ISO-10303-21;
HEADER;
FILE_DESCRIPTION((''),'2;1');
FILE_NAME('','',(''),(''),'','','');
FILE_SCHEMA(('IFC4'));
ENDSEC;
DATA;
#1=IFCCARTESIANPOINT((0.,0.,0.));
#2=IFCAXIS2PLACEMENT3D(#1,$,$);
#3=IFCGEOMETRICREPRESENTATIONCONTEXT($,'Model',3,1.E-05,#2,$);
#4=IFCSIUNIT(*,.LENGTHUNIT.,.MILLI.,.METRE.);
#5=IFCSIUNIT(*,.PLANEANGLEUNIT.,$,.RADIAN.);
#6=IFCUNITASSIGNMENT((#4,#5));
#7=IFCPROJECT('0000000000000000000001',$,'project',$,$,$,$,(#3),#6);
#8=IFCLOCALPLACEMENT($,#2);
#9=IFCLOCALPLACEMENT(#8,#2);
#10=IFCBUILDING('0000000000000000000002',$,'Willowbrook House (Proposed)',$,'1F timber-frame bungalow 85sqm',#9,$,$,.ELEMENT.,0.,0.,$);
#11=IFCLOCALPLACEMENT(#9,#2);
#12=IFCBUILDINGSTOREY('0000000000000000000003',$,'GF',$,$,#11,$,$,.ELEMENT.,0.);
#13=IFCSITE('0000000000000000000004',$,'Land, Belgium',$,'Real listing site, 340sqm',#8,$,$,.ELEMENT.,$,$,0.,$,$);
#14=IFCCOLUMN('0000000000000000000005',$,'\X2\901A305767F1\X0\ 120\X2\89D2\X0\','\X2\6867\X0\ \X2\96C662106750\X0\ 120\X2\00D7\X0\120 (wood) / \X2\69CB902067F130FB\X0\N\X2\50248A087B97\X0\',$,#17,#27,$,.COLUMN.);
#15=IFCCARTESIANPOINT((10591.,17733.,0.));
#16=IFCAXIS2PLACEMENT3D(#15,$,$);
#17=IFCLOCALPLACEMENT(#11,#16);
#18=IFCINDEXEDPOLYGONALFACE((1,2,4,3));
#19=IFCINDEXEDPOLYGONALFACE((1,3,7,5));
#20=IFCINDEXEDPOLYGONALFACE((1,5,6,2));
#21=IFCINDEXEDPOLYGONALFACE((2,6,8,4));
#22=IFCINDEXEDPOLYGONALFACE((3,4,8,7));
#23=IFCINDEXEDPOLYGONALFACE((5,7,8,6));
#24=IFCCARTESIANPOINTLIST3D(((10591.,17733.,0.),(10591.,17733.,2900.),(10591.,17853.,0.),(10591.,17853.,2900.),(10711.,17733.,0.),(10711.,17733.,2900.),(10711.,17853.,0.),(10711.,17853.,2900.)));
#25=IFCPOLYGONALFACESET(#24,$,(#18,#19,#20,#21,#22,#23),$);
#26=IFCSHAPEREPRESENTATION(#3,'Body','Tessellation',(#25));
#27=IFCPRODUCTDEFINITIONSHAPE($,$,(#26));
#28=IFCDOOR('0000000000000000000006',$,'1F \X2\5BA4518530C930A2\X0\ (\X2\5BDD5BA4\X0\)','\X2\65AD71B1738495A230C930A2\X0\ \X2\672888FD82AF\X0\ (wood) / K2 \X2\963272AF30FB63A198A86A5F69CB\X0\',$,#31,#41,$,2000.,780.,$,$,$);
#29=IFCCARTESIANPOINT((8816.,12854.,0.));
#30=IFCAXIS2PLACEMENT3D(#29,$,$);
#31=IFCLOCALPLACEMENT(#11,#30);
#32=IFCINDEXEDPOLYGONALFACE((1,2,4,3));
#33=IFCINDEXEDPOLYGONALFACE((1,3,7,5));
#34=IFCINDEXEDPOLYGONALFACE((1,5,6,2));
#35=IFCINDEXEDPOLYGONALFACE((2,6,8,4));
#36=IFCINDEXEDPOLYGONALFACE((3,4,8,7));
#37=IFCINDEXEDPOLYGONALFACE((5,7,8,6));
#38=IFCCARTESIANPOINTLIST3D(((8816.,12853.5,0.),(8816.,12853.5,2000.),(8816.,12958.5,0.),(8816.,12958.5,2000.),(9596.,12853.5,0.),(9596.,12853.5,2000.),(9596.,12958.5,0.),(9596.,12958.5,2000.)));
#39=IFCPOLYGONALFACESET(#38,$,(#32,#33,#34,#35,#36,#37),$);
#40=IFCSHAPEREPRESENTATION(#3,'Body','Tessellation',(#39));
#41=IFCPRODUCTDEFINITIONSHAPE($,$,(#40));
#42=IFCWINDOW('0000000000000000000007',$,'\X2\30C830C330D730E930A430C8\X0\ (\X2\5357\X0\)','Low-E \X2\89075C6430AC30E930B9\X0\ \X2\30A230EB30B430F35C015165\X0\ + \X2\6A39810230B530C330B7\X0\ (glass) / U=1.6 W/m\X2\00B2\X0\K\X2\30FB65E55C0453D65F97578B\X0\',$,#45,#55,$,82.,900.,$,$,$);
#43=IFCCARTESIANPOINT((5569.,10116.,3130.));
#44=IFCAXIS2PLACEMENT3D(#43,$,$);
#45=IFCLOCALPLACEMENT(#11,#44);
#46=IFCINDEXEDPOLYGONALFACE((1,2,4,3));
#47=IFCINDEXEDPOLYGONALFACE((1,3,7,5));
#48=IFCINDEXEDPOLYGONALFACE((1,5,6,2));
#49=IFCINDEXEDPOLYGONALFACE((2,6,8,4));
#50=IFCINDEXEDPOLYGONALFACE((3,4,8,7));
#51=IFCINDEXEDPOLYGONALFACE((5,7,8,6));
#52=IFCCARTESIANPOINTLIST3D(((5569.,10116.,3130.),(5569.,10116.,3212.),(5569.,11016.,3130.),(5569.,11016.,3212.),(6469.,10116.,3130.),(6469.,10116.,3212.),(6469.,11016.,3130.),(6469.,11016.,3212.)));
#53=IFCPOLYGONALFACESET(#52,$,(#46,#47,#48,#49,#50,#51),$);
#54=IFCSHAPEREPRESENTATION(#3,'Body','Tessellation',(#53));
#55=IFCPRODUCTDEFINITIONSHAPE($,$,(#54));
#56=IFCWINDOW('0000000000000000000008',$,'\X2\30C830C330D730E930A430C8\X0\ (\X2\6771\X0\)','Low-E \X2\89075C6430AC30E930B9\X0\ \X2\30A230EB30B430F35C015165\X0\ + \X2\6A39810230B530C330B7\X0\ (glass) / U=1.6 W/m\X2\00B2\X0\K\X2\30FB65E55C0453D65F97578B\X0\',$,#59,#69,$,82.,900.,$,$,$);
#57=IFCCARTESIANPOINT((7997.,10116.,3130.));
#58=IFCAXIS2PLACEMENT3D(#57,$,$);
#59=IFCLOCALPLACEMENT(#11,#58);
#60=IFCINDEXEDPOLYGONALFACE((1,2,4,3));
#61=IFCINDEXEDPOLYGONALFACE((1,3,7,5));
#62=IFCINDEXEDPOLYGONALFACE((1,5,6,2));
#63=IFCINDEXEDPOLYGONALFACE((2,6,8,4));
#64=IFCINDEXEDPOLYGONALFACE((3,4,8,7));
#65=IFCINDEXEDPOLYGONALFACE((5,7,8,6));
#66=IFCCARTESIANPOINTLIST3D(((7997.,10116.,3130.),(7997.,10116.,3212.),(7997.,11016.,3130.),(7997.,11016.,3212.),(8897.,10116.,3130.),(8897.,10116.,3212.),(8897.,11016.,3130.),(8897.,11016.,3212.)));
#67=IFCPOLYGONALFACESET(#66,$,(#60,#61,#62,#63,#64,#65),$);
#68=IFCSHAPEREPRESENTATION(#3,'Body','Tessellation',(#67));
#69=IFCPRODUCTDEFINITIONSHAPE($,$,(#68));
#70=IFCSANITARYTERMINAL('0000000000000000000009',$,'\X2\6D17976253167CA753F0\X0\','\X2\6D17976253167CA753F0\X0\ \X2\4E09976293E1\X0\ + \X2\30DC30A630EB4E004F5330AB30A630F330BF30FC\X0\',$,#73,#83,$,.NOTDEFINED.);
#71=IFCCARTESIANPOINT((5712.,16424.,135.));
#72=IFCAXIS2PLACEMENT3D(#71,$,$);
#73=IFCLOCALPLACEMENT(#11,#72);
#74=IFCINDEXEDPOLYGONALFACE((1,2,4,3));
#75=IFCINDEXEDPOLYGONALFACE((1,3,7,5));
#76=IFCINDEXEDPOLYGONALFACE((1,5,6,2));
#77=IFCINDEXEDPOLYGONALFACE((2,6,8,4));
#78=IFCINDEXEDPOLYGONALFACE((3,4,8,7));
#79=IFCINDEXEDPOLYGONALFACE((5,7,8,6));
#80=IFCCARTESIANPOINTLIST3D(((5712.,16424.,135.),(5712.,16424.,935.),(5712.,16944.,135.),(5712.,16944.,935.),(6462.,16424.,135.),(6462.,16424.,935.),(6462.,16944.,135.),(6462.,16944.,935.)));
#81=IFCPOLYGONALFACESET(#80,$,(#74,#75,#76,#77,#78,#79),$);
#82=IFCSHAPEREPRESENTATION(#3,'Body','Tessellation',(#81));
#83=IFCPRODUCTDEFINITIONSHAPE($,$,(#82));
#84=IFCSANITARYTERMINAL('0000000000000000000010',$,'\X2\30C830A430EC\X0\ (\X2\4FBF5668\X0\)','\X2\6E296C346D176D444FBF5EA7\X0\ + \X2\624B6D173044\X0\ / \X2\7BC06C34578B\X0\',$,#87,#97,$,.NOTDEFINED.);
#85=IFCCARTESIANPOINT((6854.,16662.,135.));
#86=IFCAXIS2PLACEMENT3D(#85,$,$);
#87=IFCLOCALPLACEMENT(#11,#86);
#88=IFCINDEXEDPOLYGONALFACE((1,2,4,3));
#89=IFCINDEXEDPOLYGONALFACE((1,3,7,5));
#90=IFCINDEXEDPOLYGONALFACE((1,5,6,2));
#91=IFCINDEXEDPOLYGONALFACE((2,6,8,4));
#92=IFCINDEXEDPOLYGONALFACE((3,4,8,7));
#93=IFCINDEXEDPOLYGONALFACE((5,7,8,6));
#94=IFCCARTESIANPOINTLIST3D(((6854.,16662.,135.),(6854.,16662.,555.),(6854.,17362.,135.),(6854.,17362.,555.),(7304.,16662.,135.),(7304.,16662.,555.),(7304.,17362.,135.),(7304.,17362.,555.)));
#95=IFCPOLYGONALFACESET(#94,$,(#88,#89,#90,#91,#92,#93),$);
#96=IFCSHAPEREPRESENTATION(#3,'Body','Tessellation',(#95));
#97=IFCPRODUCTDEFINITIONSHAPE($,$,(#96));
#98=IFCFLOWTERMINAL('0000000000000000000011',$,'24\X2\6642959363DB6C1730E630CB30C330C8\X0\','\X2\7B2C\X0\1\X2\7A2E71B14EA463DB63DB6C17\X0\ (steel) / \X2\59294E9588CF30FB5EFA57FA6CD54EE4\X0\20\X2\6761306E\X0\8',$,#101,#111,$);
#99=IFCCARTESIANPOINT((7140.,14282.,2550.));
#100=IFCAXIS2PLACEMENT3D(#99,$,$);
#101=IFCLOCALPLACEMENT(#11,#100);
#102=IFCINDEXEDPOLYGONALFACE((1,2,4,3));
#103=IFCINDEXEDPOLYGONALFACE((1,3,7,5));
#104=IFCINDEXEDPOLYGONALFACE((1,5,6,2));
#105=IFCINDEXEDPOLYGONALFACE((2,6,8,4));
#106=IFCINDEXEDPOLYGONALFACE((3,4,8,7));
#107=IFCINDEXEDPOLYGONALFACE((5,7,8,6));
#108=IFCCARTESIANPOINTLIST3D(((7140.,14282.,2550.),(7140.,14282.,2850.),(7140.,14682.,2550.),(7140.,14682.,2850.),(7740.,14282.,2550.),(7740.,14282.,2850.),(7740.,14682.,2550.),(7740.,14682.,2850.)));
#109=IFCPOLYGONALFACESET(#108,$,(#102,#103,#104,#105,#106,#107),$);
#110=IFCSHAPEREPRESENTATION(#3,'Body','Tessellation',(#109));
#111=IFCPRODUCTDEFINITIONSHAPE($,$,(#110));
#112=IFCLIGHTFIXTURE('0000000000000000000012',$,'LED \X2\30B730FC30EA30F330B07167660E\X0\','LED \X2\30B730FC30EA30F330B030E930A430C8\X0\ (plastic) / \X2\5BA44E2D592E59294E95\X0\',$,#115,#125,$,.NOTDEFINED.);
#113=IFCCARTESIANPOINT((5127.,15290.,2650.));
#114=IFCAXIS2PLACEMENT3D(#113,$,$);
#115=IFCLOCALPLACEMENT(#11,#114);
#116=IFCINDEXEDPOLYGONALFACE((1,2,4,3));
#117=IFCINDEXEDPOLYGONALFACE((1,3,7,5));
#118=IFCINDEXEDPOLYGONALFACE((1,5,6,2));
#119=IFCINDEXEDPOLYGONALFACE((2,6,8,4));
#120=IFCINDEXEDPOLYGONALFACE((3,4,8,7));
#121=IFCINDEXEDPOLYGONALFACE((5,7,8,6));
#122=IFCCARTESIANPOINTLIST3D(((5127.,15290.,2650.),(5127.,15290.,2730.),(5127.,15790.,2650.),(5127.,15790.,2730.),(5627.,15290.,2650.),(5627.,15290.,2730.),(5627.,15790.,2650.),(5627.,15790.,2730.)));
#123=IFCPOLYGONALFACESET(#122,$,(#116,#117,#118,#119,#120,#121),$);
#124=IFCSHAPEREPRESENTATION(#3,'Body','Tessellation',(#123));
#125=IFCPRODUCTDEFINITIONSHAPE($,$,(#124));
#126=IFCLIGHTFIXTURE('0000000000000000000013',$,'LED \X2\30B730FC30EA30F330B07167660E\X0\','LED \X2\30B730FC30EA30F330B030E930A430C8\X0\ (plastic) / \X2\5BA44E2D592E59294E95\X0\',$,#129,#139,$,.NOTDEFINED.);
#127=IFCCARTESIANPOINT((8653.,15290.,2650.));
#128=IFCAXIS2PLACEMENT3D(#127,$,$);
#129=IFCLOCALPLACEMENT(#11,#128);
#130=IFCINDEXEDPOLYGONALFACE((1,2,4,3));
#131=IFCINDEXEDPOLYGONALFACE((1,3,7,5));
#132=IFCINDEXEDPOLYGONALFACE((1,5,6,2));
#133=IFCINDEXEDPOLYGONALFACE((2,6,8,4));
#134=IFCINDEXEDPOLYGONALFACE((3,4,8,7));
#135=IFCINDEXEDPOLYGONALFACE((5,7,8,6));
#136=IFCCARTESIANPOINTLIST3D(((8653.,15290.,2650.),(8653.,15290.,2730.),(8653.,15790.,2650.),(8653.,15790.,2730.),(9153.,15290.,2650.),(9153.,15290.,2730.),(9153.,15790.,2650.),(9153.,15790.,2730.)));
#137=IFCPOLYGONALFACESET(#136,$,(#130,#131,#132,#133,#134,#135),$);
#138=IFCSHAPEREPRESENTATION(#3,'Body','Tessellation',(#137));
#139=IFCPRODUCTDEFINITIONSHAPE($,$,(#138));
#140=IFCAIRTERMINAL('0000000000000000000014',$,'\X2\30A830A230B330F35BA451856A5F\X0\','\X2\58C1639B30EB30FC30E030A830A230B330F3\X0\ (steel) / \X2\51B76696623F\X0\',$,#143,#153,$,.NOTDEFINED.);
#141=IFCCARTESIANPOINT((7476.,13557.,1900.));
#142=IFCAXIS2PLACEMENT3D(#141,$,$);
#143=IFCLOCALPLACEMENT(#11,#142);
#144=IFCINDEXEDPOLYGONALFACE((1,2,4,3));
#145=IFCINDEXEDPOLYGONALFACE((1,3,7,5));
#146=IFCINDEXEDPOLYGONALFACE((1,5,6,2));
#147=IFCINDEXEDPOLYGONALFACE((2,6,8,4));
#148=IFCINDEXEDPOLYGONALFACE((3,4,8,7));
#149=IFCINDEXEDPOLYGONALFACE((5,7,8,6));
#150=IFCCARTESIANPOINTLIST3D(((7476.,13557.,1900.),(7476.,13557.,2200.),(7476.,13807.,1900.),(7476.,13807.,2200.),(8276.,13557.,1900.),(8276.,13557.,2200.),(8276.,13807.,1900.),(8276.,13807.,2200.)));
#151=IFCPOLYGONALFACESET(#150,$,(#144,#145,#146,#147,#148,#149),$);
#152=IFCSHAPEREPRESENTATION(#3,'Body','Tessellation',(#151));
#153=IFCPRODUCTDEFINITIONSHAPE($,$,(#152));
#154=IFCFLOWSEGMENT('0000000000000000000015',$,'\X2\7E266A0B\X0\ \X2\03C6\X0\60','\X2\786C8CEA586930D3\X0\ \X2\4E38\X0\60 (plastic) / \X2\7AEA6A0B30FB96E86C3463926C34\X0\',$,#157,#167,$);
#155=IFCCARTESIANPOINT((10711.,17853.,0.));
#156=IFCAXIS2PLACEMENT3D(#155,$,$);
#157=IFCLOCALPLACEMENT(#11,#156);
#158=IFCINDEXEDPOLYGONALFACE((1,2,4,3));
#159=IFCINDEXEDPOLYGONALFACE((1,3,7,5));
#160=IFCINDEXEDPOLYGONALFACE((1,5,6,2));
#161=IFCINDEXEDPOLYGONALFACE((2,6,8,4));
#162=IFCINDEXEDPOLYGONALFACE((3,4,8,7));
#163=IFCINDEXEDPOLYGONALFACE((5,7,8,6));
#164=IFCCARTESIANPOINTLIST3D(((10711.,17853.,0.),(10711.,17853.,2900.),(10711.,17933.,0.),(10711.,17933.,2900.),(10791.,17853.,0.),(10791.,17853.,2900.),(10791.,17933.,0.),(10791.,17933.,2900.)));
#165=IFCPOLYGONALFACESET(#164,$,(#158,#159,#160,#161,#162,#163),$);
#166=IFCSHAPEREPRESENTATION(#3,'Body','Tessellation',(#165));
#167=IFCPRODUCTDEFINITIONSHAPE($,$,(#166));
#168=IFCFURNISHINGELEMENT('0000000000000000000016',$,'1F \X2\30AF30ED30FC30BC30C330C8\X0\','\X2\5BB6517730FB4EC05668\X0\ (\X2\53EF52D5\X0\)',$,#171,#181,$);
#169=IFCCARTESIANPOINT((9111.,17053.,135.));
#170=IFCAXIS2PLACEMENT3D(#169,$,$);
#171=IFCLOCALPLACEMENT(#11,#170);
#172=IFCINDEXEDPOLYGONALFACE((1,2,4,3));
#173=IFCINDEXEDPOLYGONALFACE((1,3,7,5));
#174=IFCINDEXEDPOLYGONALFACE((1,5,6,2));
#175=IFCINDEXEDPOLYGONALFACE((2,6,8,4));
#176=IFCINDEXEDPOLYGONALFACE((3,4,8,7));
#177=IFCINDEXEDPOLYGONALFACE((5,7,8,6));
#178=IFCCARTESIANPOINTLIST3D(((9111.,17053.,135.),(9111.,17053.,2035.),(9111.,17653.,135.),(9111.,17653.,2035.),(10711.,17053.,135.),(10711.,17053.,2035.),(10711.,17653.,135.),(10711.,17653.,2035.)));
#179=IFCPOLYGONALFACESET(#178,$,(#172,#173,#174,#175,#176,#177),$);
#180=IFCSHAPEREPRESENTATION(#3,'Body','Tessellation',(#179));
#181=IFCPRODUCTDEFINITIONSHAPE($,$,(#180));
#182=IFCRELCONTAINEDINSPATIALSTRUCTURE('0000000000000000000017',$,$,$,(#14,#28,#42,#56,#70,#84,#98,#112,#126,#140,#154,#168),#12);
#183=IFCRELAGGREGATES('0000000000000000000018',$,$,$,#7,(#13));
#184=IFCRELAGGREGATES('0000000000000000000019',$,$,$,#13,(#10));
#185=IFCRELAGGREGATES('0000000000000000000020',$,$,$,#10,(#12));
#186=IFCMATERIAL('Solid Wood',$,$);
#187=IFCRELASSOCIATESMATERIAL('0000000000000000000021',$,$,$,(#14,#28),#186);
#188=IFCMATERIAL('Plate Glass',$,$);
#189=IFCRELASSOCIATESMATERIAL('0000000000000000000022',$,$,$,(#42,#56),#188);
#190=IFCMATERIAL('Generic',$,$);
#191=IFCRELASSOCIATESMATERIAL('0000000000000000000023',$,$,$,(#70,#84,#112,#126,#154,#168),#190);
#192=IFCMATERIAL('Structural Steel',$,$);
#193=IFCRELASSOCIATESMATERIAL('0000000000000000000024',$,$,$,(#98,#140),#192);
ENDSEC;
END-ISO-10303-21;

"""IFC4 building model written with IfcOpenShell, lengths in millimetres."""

from ifc_helpers import new_model, si_unit, frame, frame_2d, origin, place, context, project, spatial, rectangle, extrude, material, element, save


model = new_model("IFC4")

# Units and contexts
model_context = context("Model", 3, precision=1e-05, world=origin())
ifc_project = project(units=[si_unit("LENGTHUNIT", "METRE", prefix="MILLI"), si_unit("PLANEANGLEUNIT", "RADIAN")], contexts=[model_context])

# Site, building, storey
site_placement = place(None, origin())
site = spatial("IfcSite", under=ifc_project, at=site_placement, Name="Land, Belgium", ObjectType="Real listing site, 340sqm", CompositionType="ELEMENT", RefElevation=0.0)
building_placement = place(site_placement, origin())
building = spatial("IfcBuilding", under=site, at=building_placement, Name="Willowbrook House (Proposed)", ObjectType="1F timber-frame bungalow 85sqm", CompositionType="ELEMENT", ElevationOfRefHeight=0.0, ElevationOfTerrain=0.0)
storey_placement = place(building_placement, origin())
storey = spatial("IfcBuildingStorey", under=building, at=storey_placement, Name="GF", CompositionType="ELEMENT", Elevation=0.0)

# Column
ifc_material_1 = material(Name="Solid Wood")
column_1_placement = place(storey_placement, frame((10591.0, 17733.0, 0.0)))
element("IfcColumn", 1, at=column_1_placement, inside=storey, material=ifc_material_1, Name="通し柱 120角", Description="桧 集成材 120×120 (wood) / 構造柱・N値計算", PredefinedType="COLUMN", context=model_context, shape_type="SweptSolid", body=[
    extrude(rectangle(XDim=120.0, YDim=120.0, at=frame_2d((60.0, 60.0))), frame((10591.0, 17733.0, 0.0)), (0.0, 0.0, 1.0), 2900.0),
])

# Door
door_placement = place(storey_placement, frame((8816.0, 12854.0, 0.0)))
element("IfcDoor", 2, at=door_placement, inside=storey, material=ifc_material_1, Name="1F 室内ドア (寝室)", Description="断熱玄関ドア 木製芯 (wood) / K2 防犯・採風機構", OverallHeight=2000.0, OverallWidth=780.0, context=model_context, shape_type="SweptSolid", body=[
    extrude(rectangle(XDim=780.0, YDim=105.0, at=frame_2d((390.0, 52.0))), frame((8816.0, 12854.0, 0.0)), (0.0, 0.0, 1.0), 2000.0),
])

# Windows
ifc_material_2 = material(Name="Plate Glass")
window_1_placement = place(storey_placement, frame((5569.0, 10116.0, 3130.0)))
element("IfcWindow", 3, at=window_1_placement, inside=storey, material=ifc_material_2, Name="トップライト (南)", Description="Low-E 複層ガラス アルゴン封入 + 樹脂サッシ (glass) / U=1.6 W/m²K・日射取得型", OverallHeight=82.0, OverallWidth=900.0, context=model_context, shape_type="SweptSolid", body=[
    extrude(rectangle(XDim=900.0, YDim=900.0, at=frame_2d((450.0, 450.0))), frame((5569.0, 10116.0, 3130.0)), (0.0, 0.0, 1.0), 82.0),
])
window_2_placement = place(storey_placement, frame((7997.0, 10116.0, 3130.0)))
element("IfcWindow", 4, at=window_2_placement, inside=storey, material=ifc_material_2, Name="トップライト (東)", Description="Low-E 複層ガラス アルゴン封入 + 樹脂サッシ (glass) / U=1.6 W/m²K・日射取得型", OverallHeight=82.0, OverallWidth=900.0, context=model_context, shape_type="SweptSolid", body=[
    extrude(rectangle(XDim=900.0, YDim=900.0, at=frame_2d((450.0, 450.0))), frame((7997.0, 10116.0, 3130.0)), (0.0, 0.0, 1.0), 82.0),
])

# Sanitary terminals
ifc_material_3 = material(Name="Generic")
sanitary_terminal_1_placement = place(storey_placement, frame((5712.0, 16424.0, 135.0)))
element("IfcSanitaryTerminal", 5, at=sanitary_terminal_1_placement, inside=storey, material=ifc_material_3, Name="洗面化粧台", Description="洗面化粧台 三面鏡 + ボウル一体カウンター", PredefinedType="NOTDEFINED", context=model_context, shape_type="SweptSolid", body=[
    extrude(rectangle(XDim=750.0, YDim=520.0, at=frame_2d((375.0, 260.0))), frame((5712.0, 16424.0, 135.0)), (0.0, 0.0, 1.0), 800.0),
])
sanitary_terminal_2_placement = place(storey_placement, frame((6854.0, 16662.0, 135.0)))
element("IfcSanitaryTerminal", 6, at=sanitary_terminal_2_placement, inside=storey, material=ifc_material_3, Name="トイレ (便器)", Description="温水洗浄便座 + 手洗い / 節水型", PredefinedType="NOTDEFINED", context=model_context, shape_type="SweptSolid", body=[
    extrude(rectangle(XDim=450.0, YDim=700.0, at=frame_2d((225.0, 350.0))), frame((6854.0, 16662.0, 135.0)), (0.0, 0.0, 1.0), 420.0),
])

# Flow terminal
ifc_material_4 = material(Name="Structural Steel")
flow_terminal_placement = place(storey_placement, frame((7140.0, 14282.0, 2550.0)))
element("IfcFlowTerminal", 7, at=flow_terminal_placement, inside=storey, material=ifc_material_4, Name="24時間換気ユニット", Description="第1種熱交換換気 (steel) / 天井裏・建基法令20条の8", context=model_context, shape_type="SweptSolid", body=[
    extrude(rectangle(XDim=600.0, YDim=400.0, at=frame_2d((300.0, 200.0))), frame((7140.0, 14282.0, 2550.0)), (0.0, 0.0, 1.0), 300.0),
])

# Light fixtures
light_fixture_1_placement = place(storey_placement, frame((5127.0, 15290.0, 2650.0)))
element("IfcLightFixture", 8, at=light_fixture_1_placement, inside=storey, material=ifc_material_3, Name="LED シーリング照明", Description="LED シーリングライト (plastic) / 室中央天井", PredefinedType="NOTDEFINED", context=model_context, shape_type="SweptSolid", body=[
    extrude(rectangle(XDim=500.0, YDim=500.0, at=frame_2d((250.0, 250.0))), frame((5127.0, 15290.0, 2650.0)), (0.0, 0.0, 1.0), 80.0),
])
light_fixture_2_placement = place(storey_placement, frame((8653.0, 15290.0, 2650.0)))
element("IfcLightFixture", 9, at=light_fixture_2_placement, inside=storey, material=ifc_material_3, Name="LED シーリング照明", Description="LED シーリングライト (plastic) / 室中央天井", PredefinedType="NOTDEFINED", context=model_context, shape_type="SweptSolid", body=[
    extrude(rectangle(XDim=500.0, YDim=500.0, at=frame_2d((250.0, 250.0))), frame((8653.0, 15290.0, 2650.0)), (0.0, 0.0, 1.0), 80.0),
])

# Air terminal
air_terminal_placement = place(storey_placement, frame((7476.0, 13557.0, 1900.0)))
element("IfcAirTerminal", 10, at=air_terminal_placement, inside=storey, material=ifc_material_4, Name="エアコン室内機", Description="壁掛ルームエアコン (steel) / 冷暖房", PredefinedType="NOTDEFINED", context=model_context, shape_type="SweptSolid", body=[
    extrude(rectangle(XDim=800.0, YDim=250.0, at=frame_2d((400.0, 125.0))), frame((7476.0, 13557.0, 1900.0)), (0.0, 0.0, 1.0), 300.0),
])

# Flow segment
flow_segment_placement = place(storey_placement, frame((10711.0, 17853.0, 0.0)))
element("IfcFlowSegment", 11, at=flow_segment_placement, inside=storey, material=ifc_material_3, Name="縦樋 φ60", Description="硬質塩ビ 丸60 (plastic) / 竪樋・雨水排水", context=model_context, shape_type="SweptSolid", body=[
    extrude(rectangle(XDim=80.0, YDim=80.0, at=frame_2d((40.0, 40.0))), frame((10711.0, 17853.0, 0.0)), (0.0, 0.0, 1.0), 2900.0),
])

# Furnishing element
furnishing_placement = place(storey_placement, frame((9111.0, 17053.0, 135.0)))
element("IfcFurnishingElement", 12, at=furnishing_placement, inside=storey, material=ifc_material_3, Name="1F クローゼット", Description="家具・什器 (可動)", context=model_context, shape_type="SweptSolid", body=[
    extrude(rectangle(XDim=1600.0, YDim=600.0, at=frame_2d((800.0, 300.0))), frame((9111.0, 17053.0, 135.0)), (0.0, 0.0, 1.0), 1900.0),
])

save(model, "model.ifc")
